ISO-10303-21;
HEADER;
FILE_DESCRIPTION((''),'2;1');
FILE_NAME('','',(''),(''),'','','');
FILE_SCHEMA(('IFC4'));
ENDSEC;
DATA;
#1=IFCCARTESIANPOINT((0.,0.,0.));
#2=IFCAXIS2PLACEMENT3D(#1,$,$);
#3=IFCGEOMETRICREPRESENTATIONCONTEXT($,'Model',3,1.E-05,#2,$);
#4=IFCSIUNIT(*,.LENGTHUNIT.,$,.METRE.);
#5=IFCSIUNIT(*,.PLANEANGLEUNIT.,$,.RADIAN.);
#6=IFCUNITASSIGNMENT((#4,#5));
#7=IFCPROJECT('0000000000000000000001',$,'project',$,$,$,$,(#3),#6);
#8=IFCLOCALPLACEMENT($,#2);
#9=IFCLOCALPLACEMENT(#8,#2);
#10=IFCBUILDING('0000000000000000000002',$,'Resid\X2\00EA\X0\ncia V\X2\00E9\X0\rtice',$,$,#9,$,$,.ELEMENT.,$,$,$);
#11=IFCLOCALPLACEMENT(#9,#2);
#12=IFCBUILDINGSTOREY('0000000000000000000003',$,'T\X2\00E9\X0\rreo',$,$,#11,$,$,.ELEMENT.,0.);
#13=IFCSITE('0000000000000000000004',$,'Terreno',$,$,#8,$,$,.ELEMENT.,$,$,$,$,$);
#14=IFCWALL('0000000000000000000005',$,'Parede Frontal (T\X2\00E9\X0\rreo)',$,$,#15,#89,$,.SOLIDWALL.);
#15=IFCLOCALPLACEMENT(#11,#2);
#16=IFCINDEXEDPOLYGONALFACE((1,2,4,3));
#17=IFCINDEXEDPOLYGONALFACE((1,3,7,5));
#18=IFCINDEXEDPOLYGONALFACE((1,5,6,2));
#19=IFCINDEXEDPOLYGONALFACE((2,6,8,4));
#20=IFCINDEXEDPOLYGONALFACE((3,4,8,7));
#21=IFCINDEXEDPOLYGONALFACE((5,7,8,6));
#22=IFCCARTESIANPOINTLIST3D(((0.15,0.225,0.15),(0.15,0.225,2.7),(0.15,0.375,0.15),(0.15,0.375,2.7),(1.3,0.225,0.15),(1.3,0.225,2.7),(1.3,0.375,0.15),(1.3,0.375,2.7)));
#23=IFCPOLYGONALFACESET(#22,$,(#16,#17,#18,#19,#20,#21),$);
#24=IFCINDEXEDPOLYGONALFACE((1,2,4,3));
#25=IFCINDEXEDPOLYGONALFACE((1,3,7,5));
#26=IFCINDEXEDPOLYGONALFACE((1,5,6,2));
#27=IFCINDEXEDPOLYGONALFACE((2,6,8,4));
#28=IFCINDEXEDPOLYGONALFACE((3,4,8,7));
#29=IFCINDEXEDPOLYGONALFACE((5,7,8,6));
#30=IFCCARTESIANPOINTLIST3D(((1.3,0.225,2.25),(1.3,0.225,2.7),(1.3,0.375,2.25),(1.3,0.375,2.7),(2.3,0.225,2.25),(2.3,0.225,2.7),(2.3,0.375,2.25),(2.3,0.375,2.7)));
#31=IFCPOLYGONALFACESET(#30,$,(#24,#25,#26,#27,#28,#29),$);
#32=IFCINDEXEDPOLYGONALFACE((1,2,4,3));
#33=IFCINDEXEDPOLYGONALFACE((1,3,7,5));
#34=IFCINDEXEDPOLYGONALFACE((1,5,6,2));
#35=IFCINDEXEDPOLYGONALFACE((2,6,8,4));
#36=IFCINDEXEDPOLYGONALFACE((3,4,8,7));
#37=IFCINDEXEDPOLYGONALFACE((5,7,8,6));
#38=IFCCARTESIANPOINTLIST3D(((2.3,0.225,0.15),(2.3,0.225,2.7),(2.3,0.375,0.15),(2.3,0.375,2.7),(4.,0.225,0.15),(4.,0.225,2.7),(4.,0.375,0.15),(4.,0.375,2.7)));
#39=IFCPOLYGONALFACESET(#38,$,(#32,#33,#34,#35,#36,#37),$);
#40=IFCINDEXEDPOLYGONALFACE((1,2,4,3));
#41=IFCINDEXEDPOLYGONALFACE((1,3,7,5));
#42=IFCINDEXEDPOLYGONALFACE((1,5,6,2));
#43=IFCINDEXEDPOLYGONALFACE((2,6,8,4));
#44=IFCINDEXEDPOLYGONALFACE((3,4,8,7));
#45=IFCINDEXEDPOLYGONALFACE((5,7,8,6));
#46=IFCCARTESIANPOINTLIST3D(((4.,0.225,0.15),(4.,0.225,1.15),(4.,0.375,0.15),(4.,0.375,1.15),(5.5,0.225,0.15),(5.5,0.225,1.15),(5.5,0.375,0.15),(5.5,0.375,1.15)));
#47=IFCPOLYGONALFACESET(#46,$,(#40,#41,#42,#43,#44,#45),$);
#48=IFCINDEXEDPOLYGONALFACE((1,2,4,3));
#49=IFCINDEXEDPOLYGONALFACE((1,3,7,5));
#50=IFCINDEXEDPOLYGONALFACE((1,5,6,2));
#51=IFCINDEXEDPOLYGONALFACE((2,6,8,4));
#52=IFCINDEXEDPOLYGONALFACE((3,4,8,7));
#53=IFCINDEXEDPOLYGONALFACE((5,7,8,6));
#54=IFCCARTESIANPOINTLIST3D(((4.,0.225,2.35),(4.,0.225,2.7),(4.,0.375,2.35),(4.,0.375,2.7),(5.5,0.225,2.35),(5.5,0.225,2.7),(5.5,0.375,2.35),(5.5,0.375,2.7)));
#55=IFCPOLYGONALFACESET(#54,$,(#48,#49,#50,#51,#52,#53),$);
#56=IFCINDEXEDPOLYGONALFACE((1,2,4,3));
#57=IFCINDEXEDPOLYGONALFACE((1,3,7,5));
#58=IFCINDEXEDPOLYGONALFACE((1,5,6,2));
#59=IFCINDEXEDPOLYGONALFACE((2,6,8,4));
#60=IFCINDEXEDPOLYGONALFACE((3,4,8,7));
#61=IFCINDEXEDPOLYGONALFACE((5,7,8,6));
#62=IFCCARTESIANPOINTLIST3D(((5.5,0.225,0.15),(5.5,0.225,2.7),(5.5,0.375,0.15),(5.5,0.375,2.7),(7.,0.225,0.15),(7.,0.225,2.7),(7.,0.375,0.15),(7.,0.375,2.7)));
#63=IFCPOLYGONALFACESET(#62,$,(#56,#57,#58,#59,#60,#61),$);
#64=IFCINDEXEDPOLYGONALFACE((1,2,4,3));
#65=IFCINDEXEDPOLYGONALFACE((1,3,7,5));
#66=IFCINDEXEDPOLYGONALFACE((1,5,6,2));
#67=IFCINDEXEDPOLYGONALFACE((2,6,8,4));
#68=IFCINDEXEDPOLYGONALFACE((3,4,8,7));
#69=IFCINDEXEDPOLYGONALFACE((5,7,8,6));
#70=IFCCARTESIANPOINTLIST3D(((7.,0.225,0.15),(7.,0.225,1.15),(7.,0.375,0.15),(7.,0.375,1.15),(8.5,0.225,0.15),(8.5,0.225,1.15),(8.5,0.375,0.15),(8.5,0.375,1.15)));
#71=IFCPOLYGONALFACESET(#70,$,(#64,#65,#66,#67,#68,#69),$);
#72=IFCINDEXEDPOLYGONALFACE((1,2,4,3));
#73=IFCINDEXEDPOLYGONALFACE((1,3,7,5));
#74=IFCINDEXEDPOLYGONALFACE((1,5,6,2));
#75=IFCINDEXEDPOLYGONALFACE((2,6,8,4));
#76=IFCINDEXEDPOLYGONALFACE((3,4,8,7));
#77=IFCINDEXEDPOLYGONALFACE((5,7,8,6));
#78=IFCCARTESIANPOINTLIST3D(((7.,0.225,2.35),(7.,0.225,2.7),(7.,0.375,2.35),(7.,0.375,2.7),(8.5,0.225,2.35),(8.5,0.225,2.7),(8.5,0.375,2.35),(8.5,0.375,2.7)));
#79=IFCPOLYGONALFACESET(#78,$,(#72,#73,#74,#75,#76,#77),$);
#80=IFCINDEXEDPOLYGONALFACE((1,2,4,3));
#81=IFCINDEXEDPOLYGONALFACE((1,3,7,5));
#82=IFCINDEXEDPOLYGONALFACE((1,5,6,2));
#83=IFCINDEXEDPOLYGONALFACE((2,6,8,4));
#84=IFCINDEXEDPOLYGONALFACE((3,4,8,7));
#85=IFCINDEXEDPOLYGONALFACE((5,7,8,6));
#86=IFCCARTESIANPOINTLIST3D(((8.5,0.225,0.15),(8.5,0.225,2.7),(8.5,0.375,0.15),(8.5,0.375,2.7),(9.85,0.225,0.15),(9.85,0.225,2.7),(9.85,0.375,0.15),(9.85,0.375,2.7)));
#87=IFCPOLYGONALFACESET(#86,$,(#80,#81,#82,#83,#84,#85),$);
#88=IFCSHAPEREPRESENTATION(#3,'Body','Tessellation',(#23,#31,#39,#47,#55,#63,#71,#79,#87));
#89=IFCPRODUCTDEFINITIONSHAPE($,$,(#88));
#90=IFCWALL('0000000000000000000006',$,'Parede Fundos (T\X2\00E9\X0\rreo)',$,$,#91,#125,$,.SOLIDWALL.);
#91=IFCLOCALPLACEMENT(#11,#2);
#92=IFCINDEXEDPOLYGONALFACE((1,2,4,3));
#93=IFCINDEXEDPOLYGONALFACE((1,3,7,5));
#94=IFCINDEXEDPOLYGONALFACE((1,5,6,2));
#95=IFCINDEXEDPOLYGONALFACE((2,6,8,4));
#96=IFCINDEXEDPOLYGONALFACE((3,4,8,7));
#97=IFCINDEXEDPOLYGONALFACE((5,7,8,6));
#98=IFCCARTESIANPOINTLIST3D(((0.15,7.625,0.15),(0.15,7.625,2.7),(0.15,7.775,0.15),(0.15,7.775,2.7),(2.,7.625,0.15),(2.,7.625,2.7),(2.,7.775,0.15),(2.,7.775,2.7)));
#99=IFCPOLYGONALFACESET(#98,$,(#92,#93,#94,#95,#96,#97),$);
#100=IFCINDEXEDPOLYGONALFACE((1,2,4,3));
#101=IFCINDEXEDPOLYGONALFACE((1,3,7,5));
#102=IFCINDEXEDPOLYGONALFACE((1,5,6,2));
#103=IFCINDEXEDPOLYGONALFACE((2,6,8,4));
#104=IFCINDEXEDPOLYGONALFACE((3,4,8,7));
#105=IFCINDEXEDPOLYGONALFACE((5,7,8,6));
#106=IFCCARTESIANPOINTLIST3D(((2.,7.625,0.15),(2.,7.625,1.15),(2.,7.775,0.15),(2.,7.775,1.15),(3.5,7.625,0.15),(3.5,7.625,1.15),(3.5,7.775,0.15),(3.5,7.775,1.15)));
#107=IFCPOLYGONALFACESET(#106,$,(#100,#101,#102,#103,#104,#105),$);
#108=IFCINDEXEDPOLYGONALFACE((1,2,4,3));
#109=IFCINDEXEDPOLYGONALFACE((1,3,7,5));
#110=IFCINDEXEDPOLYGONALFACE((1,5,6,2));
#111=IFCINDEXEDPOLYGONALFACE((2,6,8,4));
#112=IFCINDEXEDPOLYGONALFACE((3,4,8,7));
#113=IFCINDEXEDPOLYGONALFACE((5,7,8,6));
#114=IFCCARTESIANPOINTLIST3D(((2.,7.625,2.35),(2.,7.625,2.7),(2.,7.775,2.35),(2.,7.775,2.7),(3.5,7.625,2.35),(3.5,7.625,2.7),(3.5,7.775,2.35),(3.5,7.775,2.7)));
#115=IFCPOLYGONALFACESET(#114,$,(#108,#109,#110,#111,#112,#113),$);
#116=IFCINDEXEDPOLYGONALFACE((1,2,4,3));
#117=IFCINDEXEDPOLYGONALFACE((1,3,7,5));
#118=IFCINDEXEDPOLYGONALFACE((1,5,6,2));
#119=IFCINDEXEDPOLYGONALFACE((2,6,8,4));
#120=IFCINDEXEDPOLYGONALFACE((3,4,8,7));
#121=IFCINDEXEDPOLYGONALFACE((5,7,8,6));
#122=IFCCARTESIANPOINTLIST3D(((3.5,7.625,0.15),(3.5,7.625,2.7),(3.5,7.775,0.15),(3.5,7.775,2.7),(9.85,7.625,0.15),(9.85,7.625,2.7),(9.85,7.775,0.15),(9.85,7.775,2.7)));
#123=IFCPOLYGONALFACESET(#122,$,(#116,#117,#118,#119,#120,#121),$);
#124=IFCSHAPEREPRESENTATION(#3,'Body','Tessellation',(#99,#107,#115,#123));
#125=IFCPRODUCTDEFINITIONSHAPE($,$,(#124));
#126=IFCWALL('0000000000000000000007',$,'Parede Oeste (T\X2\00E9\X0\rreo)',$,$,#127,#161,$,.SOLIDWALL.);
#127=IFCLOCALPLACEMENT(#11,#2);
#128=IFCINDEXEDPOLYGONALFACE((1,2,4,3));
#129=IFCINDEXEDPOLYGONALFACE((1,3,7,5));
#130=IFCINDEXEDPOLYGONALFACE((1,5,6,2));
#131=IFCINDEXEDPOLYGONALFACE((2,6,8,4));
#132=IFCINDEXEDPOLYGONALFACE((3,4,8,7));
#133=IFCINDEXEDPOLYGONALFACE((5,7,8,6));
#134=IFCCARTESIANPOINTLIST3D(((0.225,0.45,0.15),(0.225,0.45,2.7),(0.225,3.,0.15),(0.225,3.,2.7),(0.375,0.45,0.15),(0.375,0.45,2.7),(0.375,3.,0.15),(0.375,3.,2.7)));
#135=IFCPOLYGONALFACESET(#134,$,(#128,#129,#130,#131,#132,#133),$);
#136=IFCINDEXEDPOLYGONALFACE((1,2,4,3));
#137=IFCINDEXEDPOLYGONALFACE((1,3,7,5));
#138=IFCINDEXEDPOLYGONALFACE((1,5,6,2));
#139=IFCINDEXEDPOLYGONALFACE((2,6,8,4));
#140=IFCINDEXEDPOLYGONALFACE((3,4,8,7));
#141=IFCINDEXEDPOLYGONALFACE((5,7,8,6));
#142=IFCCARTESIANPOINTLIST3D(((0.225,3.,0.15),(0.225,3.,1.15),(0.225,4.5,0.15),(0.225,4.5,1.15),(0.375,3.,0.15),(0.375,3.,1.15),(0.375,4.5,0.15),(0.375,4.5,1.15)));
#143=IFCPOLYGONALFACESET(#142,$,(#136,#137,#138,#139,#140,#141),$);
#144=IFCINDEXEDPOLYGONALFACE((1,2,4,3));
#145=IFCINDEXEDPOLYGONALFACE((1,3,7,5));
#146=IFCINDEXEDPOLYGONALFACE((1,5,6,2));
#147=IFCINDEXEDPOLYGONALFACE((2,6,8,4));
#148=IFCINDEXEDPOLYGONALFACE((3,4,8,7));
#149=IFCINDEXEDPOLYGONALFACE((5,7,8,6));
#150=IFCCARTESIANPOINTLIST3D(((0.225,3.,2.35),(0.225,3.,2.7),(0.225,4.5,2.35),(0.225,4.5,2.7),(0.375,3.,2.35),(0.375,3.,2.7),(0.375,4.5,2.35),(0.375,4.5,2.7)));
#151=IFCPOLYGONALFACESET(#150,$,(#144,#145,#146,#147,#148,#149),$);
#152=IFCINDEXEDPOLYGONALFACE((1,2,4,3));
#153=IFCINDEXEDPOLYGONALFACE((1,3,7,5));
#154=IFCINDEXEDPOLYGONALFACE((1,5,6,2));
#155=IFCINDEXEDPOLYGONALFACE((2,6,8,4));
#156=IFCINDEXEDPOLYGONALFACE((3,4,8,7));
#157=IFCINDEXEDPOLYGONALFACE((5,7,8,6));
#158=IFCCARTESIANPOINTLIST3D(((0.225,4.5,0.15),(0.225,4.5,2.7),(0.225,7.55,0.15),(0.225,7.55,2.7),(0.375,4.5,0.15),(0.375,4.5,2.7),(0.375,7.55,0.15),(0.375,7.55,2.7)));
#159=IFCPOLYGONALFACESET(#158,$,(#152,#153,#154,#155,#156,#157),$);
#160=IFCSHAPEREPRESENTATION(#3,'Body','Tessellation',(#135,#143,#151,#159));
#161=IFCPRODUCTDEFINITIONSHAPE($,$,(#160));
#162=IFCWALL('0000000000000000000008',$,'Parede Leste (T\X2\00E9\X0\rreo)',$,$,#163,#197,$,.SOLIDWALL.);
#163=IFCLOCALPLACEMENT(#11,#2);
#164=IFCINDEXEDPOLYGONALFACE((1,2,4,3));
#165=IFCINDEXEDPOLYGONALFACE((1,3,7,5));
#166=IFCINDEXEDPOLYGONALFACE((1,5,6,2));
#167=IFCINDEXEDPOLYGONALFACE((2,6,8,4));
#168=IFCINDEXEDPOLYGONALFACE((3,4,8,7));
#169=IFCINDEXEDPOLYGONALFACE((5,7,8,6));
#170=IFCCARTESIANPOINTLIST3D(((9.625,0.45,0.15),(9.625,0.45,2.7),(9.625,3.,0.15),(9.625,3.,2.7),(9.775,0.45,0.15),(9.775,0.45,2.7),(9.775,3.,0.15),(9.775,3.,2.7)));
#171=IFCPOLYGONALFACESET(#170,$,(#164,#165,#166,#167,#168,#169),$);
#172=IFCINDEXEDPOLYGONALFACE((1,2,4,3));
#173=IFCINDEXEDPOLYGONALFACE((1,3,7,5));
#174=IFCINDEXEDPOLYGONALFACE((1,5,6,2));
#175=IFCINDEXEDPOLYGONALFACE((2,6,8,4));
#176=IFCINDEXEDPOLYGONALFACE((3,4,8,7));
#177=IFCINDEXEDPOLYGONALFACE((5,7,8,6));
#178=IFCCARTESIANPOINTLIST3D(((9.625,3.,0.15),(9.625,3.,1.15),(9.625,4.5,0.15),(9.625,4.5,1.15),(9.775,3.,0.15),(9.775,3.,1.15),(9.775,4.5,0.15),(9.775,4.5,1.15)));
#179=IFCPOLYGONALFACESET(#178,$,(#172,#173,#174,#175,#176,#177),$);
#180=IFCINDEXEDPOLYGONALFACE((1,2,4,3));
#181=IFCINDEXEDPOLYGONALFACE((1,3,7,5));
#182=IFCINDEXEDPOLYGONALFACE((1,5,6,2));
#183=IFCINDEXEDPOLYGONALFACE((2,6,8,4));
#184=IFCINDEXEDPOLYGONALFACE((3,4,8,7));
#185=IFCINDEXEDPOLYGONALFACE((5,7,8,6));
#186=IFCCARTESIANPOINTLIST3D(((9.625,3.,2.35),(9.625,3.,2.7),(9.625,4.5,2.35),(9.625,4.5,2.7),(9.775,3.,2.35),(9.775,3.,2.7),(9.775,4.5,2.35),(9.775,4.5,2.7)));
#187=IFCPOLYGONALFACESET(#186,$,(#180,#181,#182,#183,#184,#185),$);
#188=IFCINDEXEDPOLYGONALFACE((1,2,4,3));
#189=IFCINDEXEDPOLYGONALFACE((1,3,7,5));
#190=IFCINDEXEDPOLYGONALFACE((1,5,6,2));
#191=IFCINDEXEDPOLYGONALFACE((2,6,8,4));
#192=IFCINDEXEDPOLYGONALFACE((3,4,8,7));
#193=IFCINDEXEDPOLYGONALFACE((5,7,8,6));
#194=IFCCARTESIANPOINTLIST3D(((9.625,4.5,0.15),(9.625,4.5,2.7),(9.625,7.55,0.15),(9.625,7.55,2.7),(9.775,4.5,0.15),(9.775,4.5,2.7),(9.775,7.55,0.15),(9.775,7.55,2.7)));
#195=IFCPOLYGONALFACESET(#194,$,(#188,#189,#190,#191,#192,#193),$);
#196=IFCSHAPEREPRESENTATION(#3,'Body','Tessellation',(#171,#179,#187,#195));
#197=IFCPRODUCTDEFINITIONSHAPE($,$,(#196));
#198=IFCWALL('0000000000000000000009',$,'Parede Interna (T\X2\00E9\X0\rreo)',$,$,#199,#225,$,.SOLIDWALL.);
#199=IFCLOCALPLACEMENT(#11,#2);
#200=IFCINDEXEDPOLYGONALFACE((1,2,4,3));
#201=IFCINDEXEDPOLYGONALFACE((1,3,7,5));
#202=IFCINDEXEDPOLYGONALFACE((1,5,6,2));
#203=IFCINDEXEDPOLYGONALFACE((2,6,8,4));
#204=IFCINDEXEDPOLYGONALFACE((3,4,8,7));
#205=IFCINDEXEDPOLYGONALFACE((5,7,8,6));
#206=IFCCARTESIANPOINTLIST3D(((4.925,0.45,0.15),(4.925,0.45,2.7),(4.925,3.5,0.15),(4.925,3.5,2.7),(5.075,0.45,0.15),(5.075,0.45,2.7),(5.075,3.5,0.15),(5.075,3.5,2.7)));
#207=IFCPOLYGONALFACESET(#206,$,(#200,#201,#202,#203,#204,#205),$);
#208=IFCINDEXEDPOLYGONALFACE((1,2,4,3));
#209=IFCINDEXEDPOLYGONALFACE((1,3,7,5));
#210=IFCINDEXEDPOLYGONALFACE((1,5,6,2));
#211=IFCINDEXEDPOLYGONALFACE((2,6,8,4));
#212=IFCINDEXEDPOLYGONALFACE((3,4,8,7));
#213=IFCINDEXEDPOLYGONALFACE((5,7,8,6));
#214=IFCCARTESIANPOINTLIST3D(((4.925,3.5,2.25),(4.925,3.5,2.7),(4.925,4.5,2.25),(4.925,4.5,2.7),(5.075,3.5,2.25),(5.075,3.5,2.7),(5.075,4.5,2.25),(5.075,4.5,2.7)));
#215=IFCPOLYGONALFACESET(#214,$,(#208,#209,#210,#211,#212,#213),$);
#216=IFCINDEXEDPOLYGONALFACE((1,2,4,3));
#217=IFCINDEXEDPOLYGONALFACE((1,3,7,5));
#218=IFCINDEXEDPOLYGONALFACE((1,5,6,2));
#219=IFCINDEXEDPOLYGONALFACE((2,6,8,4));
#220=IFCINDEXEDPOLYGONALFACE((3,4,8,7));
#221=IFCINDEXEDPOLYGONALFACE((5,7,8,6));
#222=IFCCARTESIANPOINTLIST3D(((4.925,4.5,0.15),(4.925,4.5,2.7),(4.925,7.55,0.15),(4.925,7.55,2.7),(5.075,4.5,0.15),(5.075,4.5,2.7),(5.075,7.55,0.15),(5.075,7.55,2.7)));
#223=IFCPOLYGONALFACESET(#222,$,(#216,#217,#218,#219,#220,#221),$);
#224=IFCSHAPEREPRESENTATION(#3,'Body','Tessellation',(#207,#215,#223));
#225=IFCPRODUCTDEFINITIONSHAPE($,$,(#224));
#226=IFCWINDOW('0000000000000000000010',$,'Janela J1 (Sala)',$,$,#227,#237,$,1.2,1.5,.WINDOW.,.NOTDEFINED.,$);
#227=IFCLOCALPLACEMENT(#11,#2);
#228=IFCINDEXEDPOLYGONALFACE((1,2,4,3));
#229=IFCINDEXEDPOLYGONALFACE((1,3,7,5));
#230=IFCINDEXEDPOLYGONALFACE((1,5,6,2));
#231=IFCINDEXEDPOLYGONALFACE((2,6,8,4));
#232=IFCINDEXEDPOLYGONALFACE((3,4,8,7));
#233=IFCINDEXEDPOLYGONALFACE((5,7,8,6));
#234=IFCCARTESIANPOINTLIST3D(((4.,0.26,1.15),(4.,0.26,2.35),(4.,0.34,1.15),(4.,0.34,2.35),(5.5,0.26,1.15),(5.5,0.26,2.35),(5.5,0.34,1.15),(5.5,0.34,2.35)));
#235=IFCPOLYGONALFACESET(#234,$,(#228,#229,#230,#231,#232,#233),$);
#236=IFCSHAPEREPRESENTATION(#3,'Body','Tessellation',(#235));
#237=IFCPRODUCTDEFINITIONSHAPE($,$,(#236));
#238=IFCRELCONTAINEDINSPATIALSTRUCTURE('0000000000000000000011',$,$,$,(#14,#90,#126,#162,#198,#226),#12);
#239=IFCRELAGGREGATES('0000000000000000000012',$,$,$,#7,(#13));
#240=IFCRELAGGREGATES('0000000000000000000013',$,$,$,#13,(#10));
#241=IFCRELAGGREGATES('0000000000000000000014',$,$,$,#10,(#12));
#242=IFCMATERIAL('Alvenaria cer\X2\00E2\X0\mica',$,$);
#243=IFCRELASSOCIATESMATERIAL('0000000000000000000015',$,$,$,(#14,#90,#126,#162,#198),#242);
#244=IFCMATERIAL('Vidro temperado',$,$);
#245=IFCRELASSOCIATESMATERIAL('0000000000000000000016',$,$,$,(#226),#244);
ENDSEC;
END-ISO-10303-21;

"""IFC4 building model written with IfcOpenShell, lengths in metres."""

from ifc_helpers import new_model, si_unit, frame, frame_2d, origin, place, context, project, spatial, rectangle, extrude, material, element, save


model = new_model("IFC4")

# Units and contexts
model_context = context("Model", 3, precision=1e-05, world=origin())
ifc_project = project(units=[si_unit("LENGTHUNIT", "METRE"), si_unit("PLANEANGLEUNIT", "RADIAN")], contexts=[model_context])

# Site, building, storey
site_placement = place(None, origin())
site = spatial("IfcSite", under=ifc_project, at=site_placement, Name="Terreno", CompositionType="ELEMENT")
building_placement = place(site_placement, origin())
building = spatial("IfcBuilding", under=site, at=building_placement, Name="Residência Vértice", CompositionType="ELEMENT")
storey_placement = place(building_placement, origin())
storey = spatial("IfcBuildingStorey", under=building, at=storey_placement, Name="Térreo", CompositionType="ELEMENT", Elevation=0.0)

# Walls
ifc_material_1 = material(Name="Alvenaria cerâmica")
wall_1_placement = place(storey_placement, origin())
element("IfcWall", 1, at=wall_1_placement, inside=storey, material=ifc_material_1, Name="Parede Frontal (Térreo)", PredefinedType="SOLIDWALL", context=model_context, shape_type="SweptSolid", body=[
    extrude(rectangle(XDim=1.15, YDim=0.15, at=frame_2d((0.725, 0.3))), frame((0.0, 0.0, 0.15)), (0.0, 0.0, 1.0), 2.55),
    extrude(rectangle(XDim=1.0, YDim=0.15, at=frame_2d((1.8, 0.3))), frame((0.0, 0.0, 2.25)), (0.0, 0.0, 1.0), 0.45),
    extrude(rectangle(XDim=1.7, YDim=0.15, at=frame_2d((3.15, 0.3))), frame((0.0, 0.0, 0.15)), (0.0, 0.0, 1.0), 2.55),
    extrude(rectangle(XDim=1.5, YDim=0.15, at=frame_2d((4.75, 0.3))), frame((0.0, 0.0, 0.15)), (0.0, 0.0, 1.0), 1.0),
    extrude(rectangle(XDim=1.5, YDim=0.15, at=frame_2d((4.75, 0.3))), frame((0.0, 0.0, 2.35)), (0.0, 0.0, 1.0), 0.35),
    extrude(rectangle(XDim=1.5, YDim=0.15, at=frame_2d((6.25, 0.3))), frame((0.0, 0.0, 0.15)), (0.0, 0.0, 1.0), 2.55),
    extrude(rectangle(XDim=1.5, YDim=0.15, at=frame_2d((7.75, 0.3))), frame((0.0, 0.0, 0.15)), (0.0, 0.0, 1.0), 1.0),
    extrude(rectangle(XDim=1.5, YDim=0.15, at=frame_2d((7.75, 0.3))), frame((0.0, 0.0, 2.35)), (0.0, 0.0, 1.0), 0.35),
    extrude(rectangle(XDim=1.35, YDim=0.15, at=frame_2d((9.175, 0.3))), frame((0.0, 0.0, 0.15)), (0.0, 0.0, 1.0), 2.55),
])
wall_2_placement = place(storey_placement, origin())
element("IfcWall", 2, at=wall_2_placement, inside=storey, material=ifc_material_1, Name="Parede Fundos (Térreo)", PredefinedType="SOLIDWALL", context=model_context, shape_type="SweptSolid", body=[
    extrude(rectangle(XDim=1.85, YDim=0.15, at=frame_2d((1.075, 7.7))), frame((0.0, 0.0, 0.15)), (0.0, 0.0, 1.0), 2.55),
    extrude(rectangle(XDim=1.5, YDim=0.15, at=frame_2d((2.75, 7.7))), frame((0.0, 0.0, 0.15)), (0.0, 0.0, 1.0), 1.0),
    extrude(rectangle(XDim=1.5, YDim=0.15, at=frame_2d((2.75, 7.7))), frame((0.0, 0.0, 2.35)), (0.0, 0.0, 1.0), 0.35),
    extrude(rectangle(XDim=6.35, YDim=0.15, at=frame_2d((6.675, 7.7))), frame((0.0, 0.0, 0.15)), (0.0, 0.0, 1.0), 2.55),
])
wall_3_placement = place(storey_placement, origin())
element("IfcWall", 3, at=wall_3_placement, inside=storey, material=ifc_material_1, Name="Parede Oeste (Térreo)", PredefinedType="SOLIDWALL", context=model_context, shape_type="SweptSolid", body=[
    extrude(rectangle(XDim=0.15, YDim=2.55, at=frame_2d((0.3, 1.725))), frame((0.0, 0.0, 0.15)), (0.0, 0.0, 1.0), 2.55),
    extrude(rectangle(XDim=0.15, YDim=1.5, at=frame_2d((0.3, 3.75))), frame((0.0, 0.0, 0.15)), (0.0, 0.0, 1.0), 1.0),
    extrude(rectangle(XDim=0.15, YDim=1.5, at=frame_2d((0.3, 3.75))), frame((0.0, 0.0, 2.35)), (0.0, 0.0, 1.0), 0.35),
    extrude(rectangle(XDim=0.15, YDim=3.05, at=frame_2d((0.3, 6.025))), frame((0.0, 0.0, 0.15)), (0.0, 0.0, 1.0), 2.55),
])
wall_4_placement = place(storey_placement, origin())
element("IfcWall", 4, at=wall_4_placement, inside=storey, material=ifc_material_1, Name="Parede Leste (Térreo)", PredefinedType="SOLIDWALL", context=model_context, shape_type="SweptSolid", body=[
    extrude(rectangle(XDim=0.15, YDim=2.55, at=frame_2d((9.7, 1.725))), frame((0.0, 0.0, 0.15)), (0.0, 0.0, 1.0), 2.55),
    extrude(rectangle(XDim=0.15, YDim=1.5, at=frame_2d((9.7, 3.75))), frame((0.0, 0.0, 0.15)), (0.0, 0.0, 1.0), 1.0),
    extrude(rectangle(XDim=0.15, YDim=1.5, at=frame_2d((9.7, 3.75))), frame((0.0, 0.0, 2.35)), (0.0, 0.0, 1.0), 0.35),
    extrude(rectangle(XDim=0.15, YDim=3.05, at=frame_2d((9.7, 6.025))), frame((0.0, 0.0, 0.15)), (0.0, 0.0, 1.0), 2.55),
])
wall_5_placement = place(storey_placement, origin())
element("IfcWall", 5, at=wall_5_placement, inside=storey, material=ifc_material_1, Name="Parede Interna (Térreo)", PredefinedType="SOLIDWALL", context=model_context, shape_type="SweptSolid", body=[
    extrude(rectangle(XDim=0.15, YDim=3.05, at=frame_2d((5.0, 1.975))), frame((0.0, 0.0, 0.15)), (0.0, 0.0, 1.0), 2.55),
    extrude(rectangle(XDim=0.15, YDim=1.0, at=frame_2d((5.0, 4.0))), frame((0.0, 0.0, 2.25)), (0.0, 0.0, 1.0), 0.45),
    extrude(rectangle(XDim=0.15, YDim=3.05, at=frame_2d((5.0, 6.025))), frame((0.0, 0.0, 0.15)), (0.0, 0.0, 1.0), 2.55),
])

# Window
ifc_material_2 = material(Name="Vidro temperado")
window_1_placement = place(storey_placement, origin())
element("IfcWindow", 6, at=window_1_placement, inside=storey, material=ifc_material_2, Name="Janela J1 (Sala)", OverallHeight=1.2, OverallWidth=1.5, PartitioningType="NOTDEFINED", PredefinedType="WINDOW", context=model_context, shape_type="SweptSolid", body=[
    extrude(rectangle(XDim=1.5, YDim=0.08, at=frame_2d((4.75, 0.3))), frame((0.0, 0.0, 1.15)), (0.0, 0.0, 1.0), 1.2),
])

save(model, "model.ifc")
